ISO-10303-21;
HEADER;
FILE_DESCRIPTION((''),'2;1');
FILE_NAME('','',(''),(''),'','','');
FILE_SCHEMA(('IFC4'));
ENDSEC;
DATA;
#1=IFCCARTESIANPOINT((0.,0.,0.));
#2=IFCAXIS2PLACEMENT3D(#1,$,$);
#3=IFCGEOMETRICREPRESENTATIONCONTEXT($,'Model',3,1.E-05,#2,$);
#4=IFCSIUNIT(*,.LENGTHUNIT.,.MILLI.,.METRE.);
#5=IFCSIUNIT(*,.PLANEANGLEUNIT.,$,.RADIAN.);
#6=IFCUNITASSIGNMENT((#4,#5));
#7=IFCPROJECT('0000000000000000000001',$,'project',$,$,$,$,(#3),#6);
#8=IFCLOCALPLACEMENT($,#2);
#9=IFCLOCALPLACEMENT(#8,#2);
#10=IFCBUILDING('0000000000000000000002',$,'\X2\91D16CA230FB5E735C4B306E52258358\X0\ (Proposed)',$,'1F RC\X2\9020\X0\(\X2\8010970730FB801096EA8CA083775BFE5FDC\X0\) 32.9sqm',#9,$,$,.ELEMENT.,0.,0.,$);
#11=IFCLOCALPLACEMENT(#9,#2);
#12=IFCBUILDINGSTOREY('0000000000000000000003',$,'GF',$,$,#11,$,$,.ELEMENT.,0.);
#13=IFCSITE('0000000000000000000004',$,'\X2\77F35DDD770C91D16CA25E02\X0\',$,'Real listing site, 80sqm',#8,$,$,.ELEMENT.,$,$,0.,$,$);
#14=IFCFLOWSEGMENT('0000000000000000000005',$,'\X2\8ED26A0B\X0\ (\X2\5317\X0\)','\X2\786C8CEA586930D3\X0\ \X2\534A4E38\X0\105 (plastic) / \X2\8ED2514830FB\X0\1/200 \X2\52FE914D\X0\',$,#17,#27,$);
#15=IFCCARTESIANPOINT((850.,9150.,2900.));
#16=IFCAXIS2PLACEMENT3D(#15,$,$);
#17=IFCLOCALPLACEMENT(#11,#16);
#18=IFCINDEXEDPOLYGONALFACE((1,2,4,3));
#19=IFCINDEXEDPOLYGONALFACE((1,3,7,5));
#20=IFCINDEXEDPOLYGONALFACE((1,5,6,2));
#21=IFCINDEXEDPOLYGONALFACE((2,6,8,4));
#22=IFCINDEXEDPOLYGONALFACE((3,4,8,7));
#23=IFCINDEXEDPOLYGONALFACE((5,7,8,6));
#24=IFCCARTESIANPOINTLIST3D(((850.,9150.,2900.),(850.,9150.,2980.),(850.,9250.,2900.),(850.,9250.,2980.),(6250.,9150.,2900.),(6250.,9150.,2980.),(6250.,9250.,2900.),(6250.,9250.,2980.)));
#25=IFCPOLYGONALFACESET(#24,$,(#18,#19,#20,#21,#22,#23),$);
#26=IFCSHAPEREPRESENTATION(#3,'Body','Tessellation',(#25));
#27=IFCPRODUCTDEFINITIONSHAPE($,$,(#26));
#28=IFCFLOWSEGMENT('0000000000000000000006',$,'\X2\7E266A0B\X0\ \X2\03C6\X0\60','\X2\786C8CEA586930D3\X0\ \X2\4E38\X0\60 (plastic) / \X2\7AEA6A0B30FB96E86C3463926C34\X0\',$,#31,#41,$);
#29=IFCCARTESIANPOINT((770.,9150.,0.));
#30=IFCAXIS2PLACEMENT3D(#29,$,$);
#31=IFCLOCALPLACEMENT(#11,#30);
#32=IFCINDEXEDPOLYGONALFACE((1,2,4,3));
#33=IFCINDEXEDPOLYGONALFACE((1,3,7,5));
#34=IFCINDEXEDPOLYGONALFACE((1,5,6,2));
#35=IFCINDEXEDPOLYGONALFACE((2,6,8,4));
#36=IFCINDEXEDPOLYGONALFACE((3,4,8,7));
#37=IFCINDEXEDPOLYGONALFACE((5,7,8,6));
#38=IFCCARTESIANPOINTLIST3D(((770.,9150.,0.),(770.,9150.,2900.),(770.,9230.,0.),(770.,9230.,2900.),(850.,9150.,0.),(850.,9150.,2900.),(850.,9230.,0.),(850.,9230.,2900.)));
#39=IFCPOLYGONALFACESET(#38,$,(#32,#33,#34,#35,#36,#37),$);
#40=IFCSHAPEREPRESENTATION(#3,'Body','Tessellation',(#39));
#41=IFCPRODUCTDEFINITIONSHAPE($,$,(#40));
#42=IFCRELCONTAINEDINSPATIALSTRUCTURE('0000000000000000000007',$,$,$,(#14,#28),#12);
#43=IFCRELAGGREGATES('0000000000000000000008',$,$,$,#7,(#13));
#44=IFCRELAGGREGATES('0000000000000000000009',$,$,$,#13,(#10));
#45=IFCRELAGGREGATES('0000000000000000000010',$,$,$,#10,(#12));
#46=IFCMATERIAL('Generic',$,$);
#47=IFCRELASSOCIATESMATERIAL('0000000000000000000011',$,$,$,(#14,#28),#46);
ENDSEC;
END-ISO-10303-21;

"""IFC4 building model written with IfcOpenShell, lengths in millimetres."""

from ifc_helpers import new_model, si_unit, frame, frame_2d, origin, place, context, project, spatial, rectangle, extrude, material, element, save


model = new_model("IFC4")

# Units and contexts
model_context = context("Model", 3, precision=1e-05, world=origin())
ifc_project = project(units=[si_unit("LENGTHUNIT", "METRE", prefix="MILLI"), si_unit("PLANEANGLEUNIT", "RADIAN")], contexts=[model_context])

# Site, building, storey
site_placement = place(None, origin())
site = spatial("IfcSite", under=ifc_project, at=site_placement, Name="石川県金沢市", ObjectType="Real listing site, 80sqm", CompositionType="ELEMENT", RefElevation=0.0)
building_placement = place(site_placement, origin())
building = spatial("IfcBuilding", under=site, at=building_placement, Name="金沢・平屋の別荘 (Proposed)", ObjectType="1F RC造(耐震・耐雪負荷対応) 32.9sqm", CompositionType="ELEMENT", ElevationOfRefHeight=0.0, ElevationOfTerrain=0.0)
storey_placement = place(building_placement, origin())
storey = spatial("IfcBuildingStorey", under=building, at=storey_placement, Name="GF", CompositionType="ELEMENT", Elevation=0.0)

# Shared definitions
ifc_material_1 = material(Name="Generic")

# Flow segments
flow_segment_1_placement = place(storey_placement, frame((850.0, 9150.0, 2900.0)))
element("IfcFlowSegment", 1, at=flow_segment_1_placement, inside=storey, material=ifc_material_1, Name="軒樋 (北)", Description="硬質塩ビ 半丸105 (plastic) / 軒先・1/200 勾配", context=model_context, shape_type="SweptSolid", body=[
    extrude(rectangle(XDim=5400.0, YDim=100.0, at=frame_2d((2700.0, 50.0))), frame((850.0, 9150.0, 2900.0)), (0.0, 0.0, 1.0), 80.0),
])
flow_segment_2_placement = place(storey_placement, frame((770.0, 9150.0, 0.0)))
element("IfcFlowSegment", 2, at=flow_segment_2_placement, inside=storey, material=ifc_material_1, Name="縦樋 φ60", Description="硬質塩ビ 丸60 (plastic) / 竪樋・雨水排水", context=model_context, shape_type="SweptSolid", body=[
    extrude(rectangle(XDim=80.0, YDim=80.0, at=frame_2d((40.0, 40.0))), frame((770.0, 9150.0, 0.0)), (0.0, 0.0, 1.0), 2900.0),
])

save(model, "model.ifc")
